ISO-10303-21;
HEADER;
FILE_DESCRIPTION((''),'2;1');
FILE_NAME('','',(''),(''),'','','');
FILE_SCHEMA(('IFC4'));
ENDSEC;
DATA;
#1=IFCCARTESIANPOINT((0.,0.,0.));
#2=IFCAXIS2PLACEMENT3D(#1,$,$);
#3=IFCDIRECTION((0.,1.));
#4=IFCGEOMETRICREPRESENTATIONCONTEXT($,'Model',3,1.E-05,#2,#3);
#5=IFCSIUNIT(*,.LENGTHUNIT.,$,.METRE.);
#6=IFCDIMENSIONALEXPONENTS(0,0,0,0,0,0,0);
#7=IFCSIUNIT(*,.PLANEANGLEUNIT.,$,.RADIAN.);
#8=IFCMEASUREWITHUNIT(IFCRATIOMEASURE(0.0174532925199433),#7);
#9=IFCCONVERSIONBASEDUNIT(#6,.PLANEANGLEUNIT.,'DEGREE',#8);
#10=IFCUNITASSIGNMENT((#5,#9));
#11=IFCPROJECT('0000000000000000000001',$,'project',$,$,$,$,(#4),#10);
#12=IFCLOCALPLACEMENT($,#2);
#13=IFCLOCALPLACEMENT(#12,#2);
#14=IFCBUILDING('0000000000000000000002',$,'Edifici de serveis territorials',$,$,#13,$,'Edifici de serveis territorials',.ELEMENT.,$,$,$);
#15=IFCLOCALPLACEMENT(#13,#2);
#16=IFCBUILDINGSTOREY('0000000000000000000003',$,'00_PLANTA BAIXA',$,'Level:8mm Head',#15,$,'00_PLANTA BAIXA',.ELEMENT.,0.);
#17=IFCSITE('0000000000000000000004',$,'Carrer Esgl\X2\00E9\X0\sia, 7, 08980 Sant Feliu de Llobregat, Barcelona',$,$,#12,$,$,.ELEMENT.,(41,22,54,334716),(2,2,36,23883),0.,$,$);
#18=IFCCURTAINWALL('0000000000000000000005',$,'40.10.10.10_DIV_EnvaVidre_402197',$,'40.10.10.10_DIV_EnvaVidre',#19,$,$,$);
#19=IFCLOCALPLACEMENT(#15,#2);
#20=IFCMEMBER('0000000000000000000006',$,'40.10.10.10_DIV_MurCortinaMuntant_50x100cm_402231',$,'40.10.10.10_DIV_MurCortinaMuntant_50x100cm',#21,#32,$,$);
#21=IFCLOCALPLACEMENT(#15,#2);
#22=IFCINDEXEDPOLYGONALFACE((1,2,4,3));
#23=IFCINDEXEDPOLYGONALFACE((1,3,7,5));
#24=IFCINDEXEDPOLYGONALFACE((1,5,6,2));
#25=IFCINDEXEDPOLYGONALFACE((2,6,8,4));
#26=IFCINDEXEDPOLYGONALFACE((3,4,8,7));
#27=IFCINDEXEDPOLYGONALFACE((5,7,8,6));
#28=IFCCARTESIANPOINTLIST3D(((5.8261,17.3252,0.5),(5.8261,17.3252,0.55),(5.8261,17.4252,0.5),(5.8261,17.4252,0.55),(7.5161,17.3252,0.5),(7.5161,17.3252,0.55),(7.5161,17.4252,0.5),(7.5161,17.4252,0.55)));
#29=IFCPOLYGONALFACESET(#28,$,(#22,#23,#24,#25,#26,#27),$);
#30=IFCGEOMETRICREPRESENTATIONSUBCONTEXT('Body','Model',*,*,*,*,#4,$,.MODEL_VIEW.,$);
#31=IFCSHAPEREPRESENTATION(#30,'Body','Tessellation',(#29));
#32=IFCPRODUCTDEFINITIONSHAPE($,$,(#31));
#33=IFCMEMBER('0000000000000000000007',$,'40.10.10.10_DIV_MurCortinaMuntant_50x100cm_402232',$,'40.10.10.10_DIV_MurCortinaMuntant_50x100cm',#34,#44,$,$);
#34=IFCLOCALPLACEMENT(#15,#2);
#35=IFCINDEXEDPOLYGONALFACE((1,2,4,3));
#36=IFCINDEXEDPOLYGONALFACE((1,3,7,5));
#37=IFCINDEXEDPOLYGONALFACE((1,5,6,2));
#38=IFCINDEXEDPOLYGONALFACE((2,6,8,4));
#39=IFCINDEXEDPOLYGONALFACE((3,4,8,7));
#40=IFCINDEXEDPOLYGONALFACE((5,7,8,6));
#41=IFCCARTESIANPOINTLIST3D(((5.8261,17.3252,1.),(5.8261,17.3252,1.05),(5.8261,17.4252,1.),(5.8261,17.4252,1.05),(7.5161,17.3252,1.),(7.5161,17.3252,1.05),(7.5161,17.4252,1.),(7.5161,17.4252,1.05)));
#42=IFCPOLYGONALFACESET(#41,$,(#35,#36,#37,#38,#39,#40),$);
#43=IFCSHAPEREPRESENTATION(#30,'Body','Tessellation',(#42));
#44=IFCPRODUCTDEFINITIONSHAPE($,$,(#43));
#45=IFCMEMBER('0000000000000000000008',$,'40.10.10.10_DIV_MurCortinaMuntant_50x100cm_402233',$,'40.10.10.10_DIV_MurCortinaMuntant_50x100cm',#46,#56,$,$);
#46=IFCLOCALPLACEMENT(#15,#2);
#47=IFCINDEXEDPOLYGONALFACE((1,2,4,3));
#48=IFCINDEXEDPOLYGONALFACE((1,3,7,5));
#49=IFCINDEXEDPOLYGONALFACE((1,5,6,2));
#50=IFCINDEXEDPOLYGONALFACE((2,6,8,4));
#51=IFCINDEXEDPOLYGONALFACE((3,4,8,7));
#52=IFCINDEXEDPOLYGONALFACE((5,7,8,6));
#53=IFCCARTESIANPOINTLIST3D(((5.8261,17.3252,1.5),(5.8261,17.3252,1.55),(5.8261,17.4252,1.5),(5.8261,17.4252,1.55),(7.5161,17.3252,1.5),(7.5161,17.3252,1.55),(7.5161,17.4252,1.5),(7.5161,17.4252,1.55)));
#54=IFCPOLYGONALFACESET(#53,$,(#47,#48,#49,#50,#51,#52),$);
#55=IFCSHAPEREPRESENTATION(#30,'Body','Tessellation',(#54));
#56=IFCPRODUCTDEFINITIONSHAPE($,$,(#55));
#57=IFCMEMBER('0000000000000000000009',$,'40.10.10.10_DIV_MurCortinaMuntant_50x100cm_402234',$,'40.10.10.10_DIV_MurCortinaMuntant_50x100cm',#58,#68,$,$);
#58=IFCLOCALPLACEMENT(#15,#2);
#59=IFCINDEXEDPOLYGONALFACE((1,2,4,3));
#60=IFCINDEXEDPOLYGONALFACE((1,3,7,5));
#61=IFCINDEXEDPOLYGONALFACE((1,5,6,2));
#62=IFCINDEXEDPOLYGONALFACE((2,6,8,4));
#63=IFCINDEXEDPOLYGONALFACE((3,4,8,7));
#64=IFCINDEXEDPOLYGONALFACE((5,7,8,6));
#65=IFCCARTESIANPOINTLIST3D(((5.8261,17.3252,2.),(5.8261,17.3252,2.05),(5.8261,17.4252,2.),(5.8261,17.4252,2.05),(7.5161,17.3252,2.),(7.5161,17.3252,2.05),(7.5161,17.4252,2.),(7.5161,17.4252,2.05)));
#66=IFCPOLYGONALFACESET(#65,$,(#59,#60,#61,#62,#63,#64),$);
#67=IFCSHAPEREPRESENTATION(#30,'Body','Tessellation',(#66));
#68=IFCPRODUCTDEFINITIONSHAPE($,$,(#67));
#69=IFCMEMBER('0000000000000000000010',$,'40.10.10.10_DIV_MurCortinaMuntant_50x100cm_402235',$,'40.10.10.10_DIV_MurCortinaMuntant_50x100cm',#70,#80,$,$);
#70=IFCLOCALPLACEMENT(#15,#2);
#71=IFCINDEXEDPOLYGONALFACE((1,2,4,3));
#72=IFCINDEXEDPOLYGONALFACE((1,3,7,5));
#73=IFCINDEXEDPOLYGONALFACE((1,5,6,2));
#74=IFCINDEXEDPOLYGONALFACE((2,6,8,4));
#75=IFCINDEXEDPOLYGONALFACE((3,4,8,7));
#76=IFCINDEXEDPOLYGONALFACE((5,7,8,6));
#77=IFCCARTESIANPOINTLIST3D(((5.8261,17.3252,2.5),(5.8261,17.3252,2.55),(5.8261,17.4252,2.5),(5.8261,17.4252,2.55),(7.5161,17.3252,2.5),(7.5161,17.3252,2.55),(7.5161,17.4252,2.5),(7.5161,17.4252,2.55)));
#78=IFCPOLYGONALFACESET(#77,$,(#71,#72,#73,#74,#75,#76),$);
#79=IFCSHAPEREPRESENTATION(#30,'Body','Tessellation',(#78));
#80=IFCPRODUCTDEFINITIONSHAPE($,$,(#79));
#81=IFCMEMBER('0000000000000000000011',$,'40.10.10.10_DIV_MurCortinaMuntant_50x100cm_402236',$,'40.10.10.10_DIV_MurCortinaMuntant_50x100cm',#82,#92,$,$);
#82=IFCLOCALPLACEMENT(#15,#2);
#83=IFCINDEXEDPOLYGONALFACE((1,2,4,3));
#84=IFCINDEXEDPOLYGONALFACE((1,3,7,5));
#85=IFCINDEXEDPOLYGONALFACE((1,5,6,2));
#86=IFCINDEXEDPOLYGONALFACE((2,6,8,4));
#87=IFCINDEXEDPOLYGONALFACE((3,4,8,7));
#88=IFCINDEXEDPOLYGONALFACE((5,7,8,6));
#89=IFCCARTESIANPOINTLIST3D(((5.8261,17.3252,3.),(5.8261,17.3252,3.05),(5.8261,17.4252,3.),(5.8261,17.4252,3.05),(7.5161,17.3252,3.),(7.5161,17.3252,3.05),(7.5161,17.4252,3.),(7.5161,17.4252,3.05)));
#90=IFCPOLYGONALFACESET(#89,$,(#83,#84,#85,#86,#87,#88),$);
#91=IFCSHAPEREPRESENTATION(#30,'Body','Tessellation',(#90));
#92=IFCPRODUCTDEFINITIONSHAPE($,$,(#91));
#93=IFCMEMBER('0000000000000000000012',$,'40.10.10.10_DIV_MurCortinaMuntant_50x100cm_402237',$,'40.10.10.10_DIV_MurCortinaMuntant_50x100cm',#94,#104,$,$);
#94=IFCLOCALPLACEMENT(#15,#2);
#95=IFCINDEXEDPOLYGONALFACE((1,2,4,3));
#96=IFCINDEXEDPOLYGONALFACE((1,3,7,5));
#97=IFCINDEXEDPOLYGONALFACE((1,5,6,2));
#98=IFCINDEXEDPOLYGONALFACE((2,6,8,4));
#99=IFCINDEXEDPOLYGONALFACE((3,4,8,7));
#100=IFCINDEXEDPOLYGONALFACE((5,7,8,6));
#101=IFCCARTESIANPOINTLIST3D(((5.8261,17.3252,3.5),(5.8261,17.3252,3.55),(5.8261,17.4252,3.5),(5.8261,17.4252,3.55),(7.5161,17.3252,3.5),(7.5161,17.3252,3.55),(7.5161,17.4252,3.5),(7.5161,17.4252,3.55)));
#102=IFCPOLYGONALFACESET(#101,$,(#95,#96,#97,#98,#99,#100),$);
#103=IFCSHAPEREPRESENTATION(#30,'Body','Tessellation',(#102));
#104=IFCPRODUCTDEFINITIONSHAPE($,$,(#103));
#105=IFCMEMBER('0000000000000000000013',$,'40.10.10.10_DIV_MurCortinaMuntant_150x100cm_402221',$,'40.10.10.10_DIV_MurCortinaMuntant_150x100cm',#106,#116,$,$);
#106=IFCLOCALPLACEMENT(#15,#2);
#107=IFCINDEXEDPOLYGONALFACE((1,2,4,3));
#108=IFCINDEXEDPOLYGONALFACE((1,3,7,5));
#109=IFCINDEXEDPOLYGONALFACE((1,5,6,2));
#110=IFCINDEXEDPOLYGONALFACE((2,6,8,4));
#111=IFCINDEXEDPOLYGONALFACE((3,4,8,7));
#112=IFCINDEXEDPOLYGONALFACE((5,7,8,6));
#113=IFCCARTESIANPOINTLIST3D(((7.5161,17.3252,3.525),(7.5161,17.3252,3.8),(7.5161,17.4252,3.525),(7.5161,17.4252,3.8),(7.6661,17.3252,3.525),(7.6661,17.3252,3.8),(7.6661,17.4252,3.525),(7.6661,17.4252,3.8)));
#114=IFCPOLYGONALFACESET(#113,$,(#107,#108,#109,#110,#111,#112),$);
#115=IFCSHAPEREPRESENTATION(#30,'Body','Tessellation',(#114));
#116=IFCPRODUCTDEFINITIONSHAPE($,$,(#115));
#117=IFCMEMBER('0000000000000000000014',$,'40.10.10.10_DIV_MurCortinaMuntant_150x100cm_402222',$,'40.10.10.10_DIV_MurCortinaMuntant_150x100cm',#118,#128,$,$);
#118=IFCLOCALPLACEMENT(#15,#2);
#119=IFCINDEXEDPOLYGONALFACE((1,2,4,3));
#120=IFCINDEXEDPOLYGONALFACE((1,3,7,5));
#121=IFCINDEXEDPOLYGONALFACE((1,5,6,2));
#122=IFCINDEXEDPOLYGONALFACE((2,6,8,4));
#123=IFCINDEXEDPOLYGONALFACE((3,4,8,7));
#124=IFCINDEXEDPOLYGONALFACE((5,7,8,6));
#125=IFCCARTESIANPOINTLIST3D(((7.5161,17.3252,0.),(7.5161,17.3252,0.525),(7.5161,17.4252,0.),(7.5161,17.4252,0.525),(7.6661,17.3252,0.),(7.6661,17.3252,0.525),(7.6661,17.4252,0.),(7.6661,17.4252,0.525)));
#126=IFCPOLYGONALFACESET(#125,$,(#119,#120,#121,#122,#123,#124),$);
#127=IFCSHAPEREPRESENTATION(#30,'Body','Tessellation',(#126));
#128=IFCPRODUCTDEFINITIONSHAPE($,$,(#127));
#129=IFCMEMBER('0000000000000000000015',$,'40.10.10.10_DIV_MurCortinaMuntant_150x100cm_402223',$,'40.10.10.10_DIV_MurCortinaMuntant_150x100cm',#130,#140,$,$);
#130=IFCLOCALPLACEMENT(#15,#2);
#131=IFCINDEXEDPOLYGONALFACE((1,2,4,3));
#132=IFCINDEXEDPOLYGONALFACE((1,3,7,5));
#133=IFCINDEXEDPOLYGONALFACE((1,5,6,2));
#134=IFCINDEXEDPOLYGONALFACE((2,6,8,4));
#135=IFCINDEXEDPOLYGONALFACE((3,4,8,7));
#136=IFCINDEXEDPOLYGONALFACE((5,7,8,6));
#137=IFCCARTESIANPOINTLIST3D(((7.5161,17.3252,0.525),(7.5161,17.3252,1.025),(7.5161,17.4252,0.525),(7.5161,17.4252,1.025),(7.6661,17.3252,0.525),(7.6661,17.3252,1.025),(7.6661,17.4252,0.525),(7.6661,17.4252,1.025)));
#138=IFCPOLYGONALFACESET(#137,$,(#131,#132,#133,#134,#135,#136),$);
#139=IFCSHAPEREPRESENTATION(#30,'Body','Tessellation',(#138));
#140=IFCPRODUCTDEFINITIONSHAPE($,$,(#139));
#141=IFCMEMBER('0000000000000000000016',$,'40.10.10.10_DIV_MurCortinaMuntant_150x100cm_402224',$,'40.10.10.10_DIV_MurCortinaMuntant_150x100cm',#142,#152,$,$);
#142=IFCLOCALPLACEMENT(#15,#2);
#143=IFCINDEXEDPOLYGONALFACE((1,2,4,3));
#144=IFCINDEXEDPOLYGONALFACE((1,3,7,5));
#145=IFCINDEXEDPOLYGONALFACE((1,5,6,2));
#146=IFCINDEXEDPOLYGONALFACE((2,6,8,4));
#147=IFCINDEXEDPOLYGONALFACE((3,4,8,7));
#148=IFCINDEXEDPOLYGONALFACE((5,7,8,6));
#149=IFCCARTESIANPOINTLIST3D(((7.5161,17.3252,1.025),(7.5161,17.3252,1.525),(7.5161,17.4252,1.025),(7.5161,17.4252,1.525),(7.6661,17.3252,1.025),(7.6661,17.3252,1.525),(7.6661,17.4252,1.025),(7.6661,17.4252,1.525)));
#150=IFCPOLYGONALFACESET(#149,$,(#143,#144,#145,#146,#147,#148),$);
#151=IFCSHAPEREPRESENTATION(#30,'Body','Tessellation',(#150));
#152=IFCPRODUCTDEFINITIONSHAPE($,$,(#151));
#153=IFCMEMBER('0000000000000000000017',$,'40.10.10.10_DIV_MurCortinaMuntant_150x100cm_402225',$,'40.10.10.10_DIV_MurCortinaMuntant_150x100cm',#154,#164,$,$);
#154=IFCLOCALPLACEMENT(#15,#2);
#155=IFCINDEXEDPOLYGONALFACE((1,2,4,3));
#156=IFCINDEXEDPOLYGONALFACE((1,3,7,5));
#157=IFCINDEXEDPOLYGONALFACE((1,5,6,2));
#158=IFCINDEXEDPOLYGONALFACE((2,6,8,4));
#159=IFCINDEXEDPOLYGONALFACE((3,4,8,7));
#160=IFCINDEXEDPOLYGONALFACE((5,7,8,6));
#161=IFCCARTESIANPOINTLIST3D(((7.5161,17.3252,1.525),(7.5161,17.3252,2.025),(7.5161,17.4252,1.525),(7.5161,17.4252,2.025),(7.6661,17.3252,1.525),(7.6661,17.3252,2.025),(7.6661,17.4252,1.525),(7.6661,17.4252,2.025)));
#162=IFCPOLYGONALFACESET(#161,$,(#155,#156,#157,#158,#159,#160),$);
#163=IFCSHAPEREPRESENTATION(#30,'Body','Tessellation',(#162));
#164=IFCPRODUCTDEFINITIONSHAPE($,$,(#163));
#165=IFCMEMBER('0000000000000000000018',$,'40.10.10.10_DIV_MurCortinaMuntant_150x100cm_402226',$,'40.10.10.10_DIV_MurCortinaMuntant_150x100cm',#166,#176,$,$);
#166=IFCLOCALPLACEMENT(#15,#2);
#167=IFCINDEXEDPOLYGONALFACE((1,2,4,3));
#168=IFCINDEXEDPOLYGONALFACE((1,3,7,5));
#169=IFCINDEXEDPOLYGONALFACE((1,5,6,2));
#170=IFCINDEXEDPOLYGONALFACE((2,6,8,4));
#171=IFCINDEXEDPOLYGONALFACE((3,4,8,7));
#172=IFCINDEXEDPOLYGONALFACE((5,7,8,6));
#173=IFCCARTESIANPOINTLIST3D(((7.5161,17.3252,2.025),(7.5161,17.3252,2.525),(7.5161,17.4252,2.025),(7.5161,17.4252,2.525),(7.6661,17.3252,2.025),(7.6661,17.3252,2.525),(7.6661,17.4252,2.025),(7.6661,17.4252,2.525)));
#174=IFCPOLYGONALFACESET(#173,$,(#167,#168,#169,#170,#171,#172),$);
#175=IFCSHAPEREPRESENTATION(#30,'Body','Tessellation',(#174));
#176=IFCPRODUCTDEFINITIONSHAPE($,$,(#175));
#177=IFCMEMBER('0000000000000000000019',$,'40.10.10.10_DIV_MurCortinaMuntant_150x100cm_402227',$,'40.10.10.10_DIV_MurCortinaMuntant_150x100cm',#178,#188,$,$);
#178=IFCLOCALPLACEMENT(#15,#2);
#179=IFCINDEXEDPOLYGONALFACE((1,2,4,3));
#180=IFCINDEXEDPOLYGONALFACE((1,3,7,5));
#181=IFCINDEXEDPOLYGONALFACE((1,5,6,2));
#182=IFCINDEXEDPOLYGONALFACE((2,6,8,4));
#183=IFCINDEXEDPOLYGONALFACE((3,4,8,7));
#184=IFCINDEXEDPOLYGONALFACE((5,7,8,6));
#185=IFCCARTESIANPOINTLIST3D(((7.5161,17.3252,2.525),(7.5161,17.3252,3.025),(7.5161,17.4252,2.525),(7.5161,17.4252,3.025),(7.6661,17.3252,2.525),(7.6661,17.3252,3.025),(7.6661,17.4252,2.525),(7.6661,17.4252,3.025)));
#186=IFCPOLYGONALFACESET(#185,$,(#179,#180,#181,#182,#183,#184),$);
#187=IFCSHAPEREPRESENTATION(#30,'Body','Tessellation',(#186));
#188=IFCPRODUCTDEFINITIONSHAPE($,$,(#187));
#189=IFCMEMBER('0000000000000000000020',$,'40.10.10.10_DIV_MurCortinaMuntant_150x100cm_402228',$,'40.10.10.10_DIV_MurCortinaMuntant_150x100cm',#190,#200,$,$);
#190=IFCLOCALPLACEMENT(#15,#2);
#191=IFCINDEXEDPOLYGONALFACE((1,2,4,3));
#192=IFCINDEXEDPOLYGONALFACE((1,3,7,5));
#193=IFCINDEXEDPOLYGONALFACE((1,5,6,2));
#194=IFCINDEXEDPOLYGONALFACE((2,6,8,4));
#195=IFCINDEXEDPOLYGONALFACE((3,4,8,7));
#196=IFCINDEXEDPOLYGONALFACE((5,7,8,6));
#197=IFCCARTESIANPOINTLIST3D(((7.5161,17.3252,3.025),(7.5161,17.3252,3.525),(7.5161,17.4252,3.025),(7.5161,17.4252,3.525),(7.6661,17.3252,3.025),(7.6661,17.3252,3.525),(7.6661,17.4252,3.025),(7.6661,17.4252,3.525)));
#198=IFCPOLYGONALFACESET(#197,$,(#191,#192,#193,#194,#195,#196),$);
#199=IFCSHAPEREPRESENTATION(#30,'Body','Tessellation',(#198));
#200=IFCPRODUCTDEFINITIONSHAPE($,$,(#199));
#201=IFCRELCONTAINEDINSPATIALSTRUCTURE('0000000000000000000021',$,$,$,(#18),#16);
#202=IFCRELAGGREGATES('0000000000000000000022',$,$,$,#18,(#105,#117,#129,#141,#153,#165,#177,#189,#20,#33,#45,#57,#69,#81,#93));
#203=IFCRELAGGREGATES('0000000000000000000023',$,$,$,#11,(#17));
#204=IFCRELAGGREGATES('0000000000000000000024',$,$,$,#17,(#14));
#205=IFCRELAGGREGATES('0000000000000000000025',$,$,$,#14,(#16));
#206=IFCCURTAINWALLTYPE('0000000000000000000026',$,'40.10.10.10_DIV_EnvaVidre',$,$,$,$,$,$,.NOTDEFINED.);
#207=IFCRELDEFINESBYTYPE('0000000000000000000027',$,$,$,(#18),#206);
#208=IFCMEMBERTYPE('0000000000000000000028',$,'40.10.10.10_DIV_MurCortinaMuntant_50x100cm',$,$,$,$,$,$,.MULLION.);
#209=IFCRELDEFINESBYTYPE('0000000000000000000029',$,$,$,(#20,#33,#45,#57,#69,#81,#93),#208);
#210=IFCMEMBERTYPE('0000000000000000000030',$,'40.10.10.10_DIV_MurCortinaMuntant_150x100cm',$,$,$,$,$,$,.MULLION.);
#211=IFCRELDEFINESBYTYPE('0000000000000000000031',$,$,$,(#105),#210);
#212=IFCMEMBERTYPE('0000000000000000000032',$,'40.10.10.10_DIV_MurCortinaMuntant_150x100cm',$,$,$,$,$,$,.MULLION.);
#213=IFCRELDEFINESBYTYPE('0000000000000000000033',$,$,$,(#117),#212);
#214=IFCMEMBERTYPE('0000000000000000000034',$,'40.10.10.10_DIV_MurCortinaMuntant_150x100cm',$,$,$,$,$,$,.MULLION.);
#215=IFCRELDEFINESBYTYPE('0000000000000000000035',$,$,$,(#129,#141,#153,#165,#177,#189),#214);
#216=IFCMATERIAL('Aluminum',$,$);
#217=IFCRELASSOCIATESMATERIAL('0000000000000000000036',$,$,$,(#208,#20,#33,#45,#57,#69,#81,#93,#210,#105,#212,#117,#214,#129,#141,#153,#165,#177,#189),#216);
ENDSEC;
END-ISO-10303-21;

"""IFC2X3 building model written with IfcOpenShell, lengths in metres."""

from ifc_helpers import new_model, entity, si_unit, converted_unit, direction, frame, origin, origin_2d_with_axis, place, context, subcontext, project, spatial, rectangle, extrude, source, transform, mapped, material, type_object, type_shapes, element, aggregate, save


model = new_model("IFC2X3")

# Units and contexts
model_context = context("Model", 3, precision=1e-05, world=origin(), true_north=direction((0.0, 1.0)))
body_context = subcontext(model_context, "Body", "Model", "MODEL_VIEW")
ifc_project = project(units=[si_unit("LENGTHUNIT", "METRE"), converted_unit("PLANEANGLEUNIT", "DEGREE", entity("IfcRatioMeasure", 0.0174532925199433), si_unit("PLANEANGLEUNIT", "RADIAN"), dimensions=[0, 0, 0, 0, 0, 0, 0])], contexts=[model_context])

# Site, building, storey
site_placement = place(None, origin())
site = spatial("IfcSite", under=ifc_project, at=site_placement, Name="Carrer Església, 7, 08980 Sant Feliu de Llobregat, Barcelona", CompositionType="ELEMENT", RefLatitude=(41, 22, 54, 334716), RefLongitude=(2, 2, 36, 23883), RefElevation=0.0)
building_placement = place(site_placement, origin())
building = spatial("IfcBuilding", under=site, at=building_placement, Name="Edifici de serveis territorials", LongName="Edifici de serveis territorials", CompositionType="ELEMENT")
storey_placement = place(building_placement, origin())
storey = spatial("IfcBuildingStorey", under=building, at=storey_placement, Name="00_PLANTA BAIXA", ObjectType="Level:8mm Head", LongName="00_PLANTA BAIXA", CompositionType="ELEMENT", Elevation=0.0)

# Curtain wall
curtain_wall_type = type_object("IfcCurtainWallType", Name="40.10.10.10_DIV_EnvaVidre", PredefinedType="NOTDEFINED")
ifc_material_1 = material(Name="Aluminum")
curtain_wall_1_placement = place(storey_placement, origin())
curtain_wall_1 = element("IfcCurtainWall", 1, at=curtain_wall_1_placement, inside=storey, type_object=curtain_wall_type, Name="40.10.10.10_DIV_EnvaVidre_402197", ObjectType="40.10.10.10_DIV_EnvaVidre")

# Members
member_type_1 = type_object("IfcMemberType", Name="40.10.10.10_DIV_MurCortinaMuntant_50x100cm", PredefinedType="MULLION", material=ifc_material_1)
shared_shape_1 = source(origin(), body_context, "Body", "SweptSolid", [
    extrude(rectangle(XDim=0.1, YDim=0.05, at=origin_2d_with_axis()), frame((0.0, 0.0, -1.69), z_axis=(0.0, 0.0, 1.0), x_axis=(0.0, -1.0, 0.0)), (0.0, 0.0, 1.0), 1.69),
])
type_shapes(member_type_1, [shared_shape_1])
member_1_placement = place(storey_placement, frame((5.8261, 17.3752, 0.525), z_axis=(-1.0, 0.0, 0.0), x_axis=(0.0, 0.0, 1.0)))
member_1 = element("IfcMember", 2, at=member_1_placement, type_object=member_type_1, material=ifc_material_1, Name="40.10.10.10_DIV_MurCortinaMuntant_50x100cm_402231", ObjectType="40.10.10.10_DIV_MurCortinaMuntant_50x100cm", context=body_context, shape_type="MappedRepresentation", body=[
    mapped(shared_shape_1, transform((0.0, 0.0, 0.0), scale=1.0)),
])
member_2_placement = place(storey_placement, frame((5.8261, 17.3752, 1.025), z_axis=(-1.0, 0.0, 0.0), x_axis=(0.0, 0.0, 1.0)))
member_2 = element("IfcMember", 3, at=member_2_placement, type_object=member_type_1, material=ifc_material_1, Name="40.10.10.10_DIV_MurCortinaMuntant_50x100cm_402232", ObjectType="40.10.10.10_DIV_MurCortinaMuntant_50x100cm", context=body_context, shape_type="MappedRepresentation", body=[
    mapped(shared_shape_1, transform((0.0, 0.0, 0.0), scale=1.0)),
])
member_3_placement = place(storey_placement, frame((5.8261, 17.3752, 1.525), z_axis=(-1.0, 0.0, 0.0), x_axis=(0.0, 0.0, 1.0)))
member_3 = element("IfcMember", 4, at=member_3_placement, type_object=member_type_1, material=ifc_material_1, Name="40.10.10.10_DIV_MurCortinaMuntant_50x100cm_402233", ObjectType="40.10.10.10_DIV_MurCortinaMuntant_50x100cm", context=body_context, shape_type="MappedRepresentation", body=[
    mapped(shared_shape_1, transform((0.0, 0.0, 0.0), scale=1.0)),
])
member_4_placement = place(storey_placement, frame((5.8261, 17.3752, 2.025), z_axis=(-1.0, 0.0, 0.0), x_axis=(0.0, 0.0, 1.0)))
member_4 = element("IfcMember", 5, at=member_4_placement, type_object=member_type_1, material=ifc_material_1, Name="40.10.10.10_DIV_MurCortinaMuntant_50x100cm_402234", ObjectType="40.10.10.10_DIV_MurCortinaMuntant_50x100cm", context=body_context, shape_type="MappedRepresentation", body=[
    mapped(shared_shape_1, transform((0.0, 0.0, 0.0), scale=1.0)),
])
member_5_placement = place(storey_placement, frame((5.8261, 17.3752, 2.525), z_axis=(-1.0, 0.0, 0.0), x_axis=(0.0, 0.0, 1.0)))
member_5 = element("IfcMember", 6, at=member_5_placement, type_object=member_type_1, material=ifc_material_1, Name="40.10.10.10_DIV_MurCortinaMuntant_50x100cm_402235", ObjectType="40.10.10.10_DIV_MurCortinaMuntant_50x100cm", context=body_context, shape_type="MappedRepresentation", body=[
    mapped(shared_shape_1, transform((0.0, 0.0, 0.0), scale=1.0)),
])
member_6_placement = place(storey_placement, frame((5.8261, 17.3752, 3.025), z_axis=(-1.0, 0.0, 0.0), x_axis=(0.0, 0.0, 1.0)))
member_6 = element("IfcMember", 7, at=member_6_placement, type_object=member_type_1, material=ifc_material_1, Name="40.10.10.10_DIV_MurCortinaMuntant_50x100cm_402236", ObjectType="40.10.10.10_DIV_MurCortinaMuntant_50x100cm", context=body_context, shape_type="MappedRepresentation", body=[
    mapped(shared_shape_1, transform((0.0, 0.0, 0.0), scale=1.0)),
])
member_7_placement = place(storey_placement, frame((5.8261, 17.3752, 3.525), z_axis=(-1.0, 0.0, 0.0), x_axis=(0.0, 0.0, 1.0)))
member_7 = element("IfcMember", 8, at=member_7_placement, type_object=member_type_1, material=ifc_material_1, Name="40.10.10.10_DIV_MurCortinaMuntant_50x100cm_402237", ObjectType="40.10.10.10_DIV_MurCortinaMuntant_50x100cm", context=body_context, shape_type="MappedRepresentation", body=[
    mapped(shared_shape_1, transform((0.0, 0.0, 0.0), scale=1.0)),
])
member_type_2 = type_object("IfcMemberType", Name="40.10.10.10_DIV_MurCortinaMuntant_150x100cm", PredefinedType="MULLION", material=ifc_material_1)
shared_shape_2 = source(origin(), body_context, "Body", "SweptSolid", [
    extrude(rectangle(XDim=0.1, YDim=0.15, at=origin_2d_with_axis()), frame((-0.075, 0.0, -0.275), z_axis=(0.0, 0.0, 1.0), x_axis=(0.0, -1.0, 0.0)), (0.0, 0.0, 1.0), 0.275),
])
type_shapes(member_type_2, [shared_shape_2])
member_8_placement = place(storey_placement, frame((7.6661, 17.3752, 3.8)))
member_8 = element("IfcMember", 9, at=member_8_placement, type_object=member_type_2, material=ifc_material_1, Name="40.10.10.10_DIV_MurCortinaMuntant_150x100cm_402221", ObjectType="40.10.10.10_DIV_MurCortinaMuntant_150x100cm", context=body_context, shape_type="MappedRepresentation", body=[
    mapped(shared_shape_2, transform((0.0, 0.0, 0.0), scale=1.0)),
])
member_type_3 = type_object("IfcMemberType", Name="40.10.10.10_DIV_MurCortinaMuntant_150x100cm", PredefinedType="MULLION", material=ifc_material_1)
shared_shape_3 = source(origin(), body_context, "Body", "SweptSolid", [
    extrude(rectangle(XDim=0.1, YDim=0.15, at=origin_2d_with_axis()), frame((-0.075, 0.0, -0.525), z_axis=(0.0, 0.0, 1.0), x_axis=(0.0, -1.0, 0.0)), (0.0, 0.0, 1.0), 0.525),
])
type_shapes(member_type_3, [shared_shape_3])
member_9_placement = place(storey_placement, frame((7.6661, 17.3752, 0.525)))
member_9 = element("IfcMember", 10, at=member_9_placement, type_object=member_type_3, material=ifc_material_1, Name="40.10.10.10_DIV_MurCortinaMuntant_150x100cm_402222", ObjectType="40.10.10.10_DIV_MurCortinaMuntant_150x100cm", context=body_context, shape_type="MappedRepresentation", body=[
    mapped(shared_shape_3, transform((0.0, 0.0, 0.0), scale=1.0)),
])
member_type_4 = type_object("IfcMemberType", Name="40.10.10.10_DIV_MurCortinaMuntant_150x100cm", PredefinedType="MULLION", material=ifc_material_1)
shared_shape_4 = source(origin(), body_context, "Body", "SweptSolid", [
    extrude(rectangle(XDim=0.1, YDim=0.15, at=origin_2d_with_axis()), frame((-0.075, 0.0, -0.5), z_axis=(0.0, 0.0, 1.0), x_axis=(0.0, -1.0, 0.0)), (0.0, 0.0, 1.0), 0.5),
])
type_shapes(member_type_4, [shared_shape_4])
member_10_placement = place(storey_placement, frame((7.6661, 17.3752, 1.025)))
member_10 = element("IfcMember", 11, at=member_10_placement, type_object=member_type_4, material=ifc_material_1, Name="40.10.10.10_DIV_MurCortinaMuntant_150x100cm_402223", ObjectType="40.10.10.10_DIV_MurCortinaMuntant_150x100cm", context=body_context, shape_type="MappedRepresentation", body=[
    mapped(shared_shape_4, transform((0.0, 0.0, 0.0), scale=1.0)),
])
member_11_placement = place(storey_placement, frame((7.6661, 17.3752, 1.525)))
member_11 = element("IfcMember", 12, at=member_11_placement, type_object=member_type_4, material=ifc_material_1, Name="40.10.10.10_DIV_MurCortinaMuntant_150x100cm_402224", ObjectType="40.10.10.10_DIV_MurCortinaMuntant_150x100cm", context=body_context, shape_type="MappedRepresentation", body=[
    mapped(shared_shape_4, transform((0.0, 0.0, 0.0), scale=1.0)),
])
member_12_placement = place(storey_placement, frame((7.6661, 17.3752, 2.025)))
member_12 = element("IfcMember", 13, at=member_12_placement, type_object=member_type_4, material=ifc_material_1, Name="40.10.10.10_DIV_MurCortinaMuntant_150x100cm_402225", ObjectType="40.10.10.10_DIV_MurCortinaMuntant_150x100cm", context=body_context, shape_type="MappedRepresentation", body=[
    mapped(shared_shape_4, transform((0.0, 0.0, 0.0), scale=1.0)),
])
member_13_placement = place(storey_placement, frame((7.6661, 17.3752, 2.525)))
member_13 = element("IfcMember", 14, at=member_13_placement, type_object=member_type_4, material=ifc_material_1, Name="40.10.10.10_DIV_MurCortinaMuntant_150x100cm_402226", ObjectType="40.10.10.10_DIV_MurCortinaMuntant_150x100cm", context=body_context, shape_type="MappedRepresentation", body=[
    mapped(shared_shape_4, transform((0.0, 0.0, 0.0), scale=1.0)),
])
member_14_placement = place(storey_placement, frame((7.6661, 17.3752, 3.025)))
member_14 = element("IfcMember", 15, at=member_14_placement, type_object=member_type_4, material=ifc_material_1, Name="40.10.10.10_DIV_MurCortinaMuntant_150x100cm_402227", ObjectType="40.10.10.10_DIV_MurCortinaMuntant_150x100cm", context=body_context, shape_type="MappedRepresentation", body=[
    mapped(shared_shape_4, transform((0.0, 0.0, 0.0), scale=1.0)),
])
member_15_placement = place(storey_placement, frame((7.6661, 17.3752, 3.525)))
member_15 = element("IfcMember", 16, at=member_15_placement, type_object=member_type_4, material=ifc_material_1, Name="40.10.10.10_DIV_MurCortinaMuntant_150x100cm_402228", ObjectType="40.10.10.10_DIV_MurCortinaMuntant_150x100cm", context=body_context, shape_type="MappedRepresentation", body=[
    mapped(shared_shape_4, transform((0.0, 0.0, 0.0), scale=1.0)),
])
aggregate(curtain_wall_1, [member_8, member_9, member_10, member_11, member_12, member_13, member_14, member_15, member_1, member_2, member_3, member_4, member_5, member_6, member_7])

save(model, "model.ifc")
